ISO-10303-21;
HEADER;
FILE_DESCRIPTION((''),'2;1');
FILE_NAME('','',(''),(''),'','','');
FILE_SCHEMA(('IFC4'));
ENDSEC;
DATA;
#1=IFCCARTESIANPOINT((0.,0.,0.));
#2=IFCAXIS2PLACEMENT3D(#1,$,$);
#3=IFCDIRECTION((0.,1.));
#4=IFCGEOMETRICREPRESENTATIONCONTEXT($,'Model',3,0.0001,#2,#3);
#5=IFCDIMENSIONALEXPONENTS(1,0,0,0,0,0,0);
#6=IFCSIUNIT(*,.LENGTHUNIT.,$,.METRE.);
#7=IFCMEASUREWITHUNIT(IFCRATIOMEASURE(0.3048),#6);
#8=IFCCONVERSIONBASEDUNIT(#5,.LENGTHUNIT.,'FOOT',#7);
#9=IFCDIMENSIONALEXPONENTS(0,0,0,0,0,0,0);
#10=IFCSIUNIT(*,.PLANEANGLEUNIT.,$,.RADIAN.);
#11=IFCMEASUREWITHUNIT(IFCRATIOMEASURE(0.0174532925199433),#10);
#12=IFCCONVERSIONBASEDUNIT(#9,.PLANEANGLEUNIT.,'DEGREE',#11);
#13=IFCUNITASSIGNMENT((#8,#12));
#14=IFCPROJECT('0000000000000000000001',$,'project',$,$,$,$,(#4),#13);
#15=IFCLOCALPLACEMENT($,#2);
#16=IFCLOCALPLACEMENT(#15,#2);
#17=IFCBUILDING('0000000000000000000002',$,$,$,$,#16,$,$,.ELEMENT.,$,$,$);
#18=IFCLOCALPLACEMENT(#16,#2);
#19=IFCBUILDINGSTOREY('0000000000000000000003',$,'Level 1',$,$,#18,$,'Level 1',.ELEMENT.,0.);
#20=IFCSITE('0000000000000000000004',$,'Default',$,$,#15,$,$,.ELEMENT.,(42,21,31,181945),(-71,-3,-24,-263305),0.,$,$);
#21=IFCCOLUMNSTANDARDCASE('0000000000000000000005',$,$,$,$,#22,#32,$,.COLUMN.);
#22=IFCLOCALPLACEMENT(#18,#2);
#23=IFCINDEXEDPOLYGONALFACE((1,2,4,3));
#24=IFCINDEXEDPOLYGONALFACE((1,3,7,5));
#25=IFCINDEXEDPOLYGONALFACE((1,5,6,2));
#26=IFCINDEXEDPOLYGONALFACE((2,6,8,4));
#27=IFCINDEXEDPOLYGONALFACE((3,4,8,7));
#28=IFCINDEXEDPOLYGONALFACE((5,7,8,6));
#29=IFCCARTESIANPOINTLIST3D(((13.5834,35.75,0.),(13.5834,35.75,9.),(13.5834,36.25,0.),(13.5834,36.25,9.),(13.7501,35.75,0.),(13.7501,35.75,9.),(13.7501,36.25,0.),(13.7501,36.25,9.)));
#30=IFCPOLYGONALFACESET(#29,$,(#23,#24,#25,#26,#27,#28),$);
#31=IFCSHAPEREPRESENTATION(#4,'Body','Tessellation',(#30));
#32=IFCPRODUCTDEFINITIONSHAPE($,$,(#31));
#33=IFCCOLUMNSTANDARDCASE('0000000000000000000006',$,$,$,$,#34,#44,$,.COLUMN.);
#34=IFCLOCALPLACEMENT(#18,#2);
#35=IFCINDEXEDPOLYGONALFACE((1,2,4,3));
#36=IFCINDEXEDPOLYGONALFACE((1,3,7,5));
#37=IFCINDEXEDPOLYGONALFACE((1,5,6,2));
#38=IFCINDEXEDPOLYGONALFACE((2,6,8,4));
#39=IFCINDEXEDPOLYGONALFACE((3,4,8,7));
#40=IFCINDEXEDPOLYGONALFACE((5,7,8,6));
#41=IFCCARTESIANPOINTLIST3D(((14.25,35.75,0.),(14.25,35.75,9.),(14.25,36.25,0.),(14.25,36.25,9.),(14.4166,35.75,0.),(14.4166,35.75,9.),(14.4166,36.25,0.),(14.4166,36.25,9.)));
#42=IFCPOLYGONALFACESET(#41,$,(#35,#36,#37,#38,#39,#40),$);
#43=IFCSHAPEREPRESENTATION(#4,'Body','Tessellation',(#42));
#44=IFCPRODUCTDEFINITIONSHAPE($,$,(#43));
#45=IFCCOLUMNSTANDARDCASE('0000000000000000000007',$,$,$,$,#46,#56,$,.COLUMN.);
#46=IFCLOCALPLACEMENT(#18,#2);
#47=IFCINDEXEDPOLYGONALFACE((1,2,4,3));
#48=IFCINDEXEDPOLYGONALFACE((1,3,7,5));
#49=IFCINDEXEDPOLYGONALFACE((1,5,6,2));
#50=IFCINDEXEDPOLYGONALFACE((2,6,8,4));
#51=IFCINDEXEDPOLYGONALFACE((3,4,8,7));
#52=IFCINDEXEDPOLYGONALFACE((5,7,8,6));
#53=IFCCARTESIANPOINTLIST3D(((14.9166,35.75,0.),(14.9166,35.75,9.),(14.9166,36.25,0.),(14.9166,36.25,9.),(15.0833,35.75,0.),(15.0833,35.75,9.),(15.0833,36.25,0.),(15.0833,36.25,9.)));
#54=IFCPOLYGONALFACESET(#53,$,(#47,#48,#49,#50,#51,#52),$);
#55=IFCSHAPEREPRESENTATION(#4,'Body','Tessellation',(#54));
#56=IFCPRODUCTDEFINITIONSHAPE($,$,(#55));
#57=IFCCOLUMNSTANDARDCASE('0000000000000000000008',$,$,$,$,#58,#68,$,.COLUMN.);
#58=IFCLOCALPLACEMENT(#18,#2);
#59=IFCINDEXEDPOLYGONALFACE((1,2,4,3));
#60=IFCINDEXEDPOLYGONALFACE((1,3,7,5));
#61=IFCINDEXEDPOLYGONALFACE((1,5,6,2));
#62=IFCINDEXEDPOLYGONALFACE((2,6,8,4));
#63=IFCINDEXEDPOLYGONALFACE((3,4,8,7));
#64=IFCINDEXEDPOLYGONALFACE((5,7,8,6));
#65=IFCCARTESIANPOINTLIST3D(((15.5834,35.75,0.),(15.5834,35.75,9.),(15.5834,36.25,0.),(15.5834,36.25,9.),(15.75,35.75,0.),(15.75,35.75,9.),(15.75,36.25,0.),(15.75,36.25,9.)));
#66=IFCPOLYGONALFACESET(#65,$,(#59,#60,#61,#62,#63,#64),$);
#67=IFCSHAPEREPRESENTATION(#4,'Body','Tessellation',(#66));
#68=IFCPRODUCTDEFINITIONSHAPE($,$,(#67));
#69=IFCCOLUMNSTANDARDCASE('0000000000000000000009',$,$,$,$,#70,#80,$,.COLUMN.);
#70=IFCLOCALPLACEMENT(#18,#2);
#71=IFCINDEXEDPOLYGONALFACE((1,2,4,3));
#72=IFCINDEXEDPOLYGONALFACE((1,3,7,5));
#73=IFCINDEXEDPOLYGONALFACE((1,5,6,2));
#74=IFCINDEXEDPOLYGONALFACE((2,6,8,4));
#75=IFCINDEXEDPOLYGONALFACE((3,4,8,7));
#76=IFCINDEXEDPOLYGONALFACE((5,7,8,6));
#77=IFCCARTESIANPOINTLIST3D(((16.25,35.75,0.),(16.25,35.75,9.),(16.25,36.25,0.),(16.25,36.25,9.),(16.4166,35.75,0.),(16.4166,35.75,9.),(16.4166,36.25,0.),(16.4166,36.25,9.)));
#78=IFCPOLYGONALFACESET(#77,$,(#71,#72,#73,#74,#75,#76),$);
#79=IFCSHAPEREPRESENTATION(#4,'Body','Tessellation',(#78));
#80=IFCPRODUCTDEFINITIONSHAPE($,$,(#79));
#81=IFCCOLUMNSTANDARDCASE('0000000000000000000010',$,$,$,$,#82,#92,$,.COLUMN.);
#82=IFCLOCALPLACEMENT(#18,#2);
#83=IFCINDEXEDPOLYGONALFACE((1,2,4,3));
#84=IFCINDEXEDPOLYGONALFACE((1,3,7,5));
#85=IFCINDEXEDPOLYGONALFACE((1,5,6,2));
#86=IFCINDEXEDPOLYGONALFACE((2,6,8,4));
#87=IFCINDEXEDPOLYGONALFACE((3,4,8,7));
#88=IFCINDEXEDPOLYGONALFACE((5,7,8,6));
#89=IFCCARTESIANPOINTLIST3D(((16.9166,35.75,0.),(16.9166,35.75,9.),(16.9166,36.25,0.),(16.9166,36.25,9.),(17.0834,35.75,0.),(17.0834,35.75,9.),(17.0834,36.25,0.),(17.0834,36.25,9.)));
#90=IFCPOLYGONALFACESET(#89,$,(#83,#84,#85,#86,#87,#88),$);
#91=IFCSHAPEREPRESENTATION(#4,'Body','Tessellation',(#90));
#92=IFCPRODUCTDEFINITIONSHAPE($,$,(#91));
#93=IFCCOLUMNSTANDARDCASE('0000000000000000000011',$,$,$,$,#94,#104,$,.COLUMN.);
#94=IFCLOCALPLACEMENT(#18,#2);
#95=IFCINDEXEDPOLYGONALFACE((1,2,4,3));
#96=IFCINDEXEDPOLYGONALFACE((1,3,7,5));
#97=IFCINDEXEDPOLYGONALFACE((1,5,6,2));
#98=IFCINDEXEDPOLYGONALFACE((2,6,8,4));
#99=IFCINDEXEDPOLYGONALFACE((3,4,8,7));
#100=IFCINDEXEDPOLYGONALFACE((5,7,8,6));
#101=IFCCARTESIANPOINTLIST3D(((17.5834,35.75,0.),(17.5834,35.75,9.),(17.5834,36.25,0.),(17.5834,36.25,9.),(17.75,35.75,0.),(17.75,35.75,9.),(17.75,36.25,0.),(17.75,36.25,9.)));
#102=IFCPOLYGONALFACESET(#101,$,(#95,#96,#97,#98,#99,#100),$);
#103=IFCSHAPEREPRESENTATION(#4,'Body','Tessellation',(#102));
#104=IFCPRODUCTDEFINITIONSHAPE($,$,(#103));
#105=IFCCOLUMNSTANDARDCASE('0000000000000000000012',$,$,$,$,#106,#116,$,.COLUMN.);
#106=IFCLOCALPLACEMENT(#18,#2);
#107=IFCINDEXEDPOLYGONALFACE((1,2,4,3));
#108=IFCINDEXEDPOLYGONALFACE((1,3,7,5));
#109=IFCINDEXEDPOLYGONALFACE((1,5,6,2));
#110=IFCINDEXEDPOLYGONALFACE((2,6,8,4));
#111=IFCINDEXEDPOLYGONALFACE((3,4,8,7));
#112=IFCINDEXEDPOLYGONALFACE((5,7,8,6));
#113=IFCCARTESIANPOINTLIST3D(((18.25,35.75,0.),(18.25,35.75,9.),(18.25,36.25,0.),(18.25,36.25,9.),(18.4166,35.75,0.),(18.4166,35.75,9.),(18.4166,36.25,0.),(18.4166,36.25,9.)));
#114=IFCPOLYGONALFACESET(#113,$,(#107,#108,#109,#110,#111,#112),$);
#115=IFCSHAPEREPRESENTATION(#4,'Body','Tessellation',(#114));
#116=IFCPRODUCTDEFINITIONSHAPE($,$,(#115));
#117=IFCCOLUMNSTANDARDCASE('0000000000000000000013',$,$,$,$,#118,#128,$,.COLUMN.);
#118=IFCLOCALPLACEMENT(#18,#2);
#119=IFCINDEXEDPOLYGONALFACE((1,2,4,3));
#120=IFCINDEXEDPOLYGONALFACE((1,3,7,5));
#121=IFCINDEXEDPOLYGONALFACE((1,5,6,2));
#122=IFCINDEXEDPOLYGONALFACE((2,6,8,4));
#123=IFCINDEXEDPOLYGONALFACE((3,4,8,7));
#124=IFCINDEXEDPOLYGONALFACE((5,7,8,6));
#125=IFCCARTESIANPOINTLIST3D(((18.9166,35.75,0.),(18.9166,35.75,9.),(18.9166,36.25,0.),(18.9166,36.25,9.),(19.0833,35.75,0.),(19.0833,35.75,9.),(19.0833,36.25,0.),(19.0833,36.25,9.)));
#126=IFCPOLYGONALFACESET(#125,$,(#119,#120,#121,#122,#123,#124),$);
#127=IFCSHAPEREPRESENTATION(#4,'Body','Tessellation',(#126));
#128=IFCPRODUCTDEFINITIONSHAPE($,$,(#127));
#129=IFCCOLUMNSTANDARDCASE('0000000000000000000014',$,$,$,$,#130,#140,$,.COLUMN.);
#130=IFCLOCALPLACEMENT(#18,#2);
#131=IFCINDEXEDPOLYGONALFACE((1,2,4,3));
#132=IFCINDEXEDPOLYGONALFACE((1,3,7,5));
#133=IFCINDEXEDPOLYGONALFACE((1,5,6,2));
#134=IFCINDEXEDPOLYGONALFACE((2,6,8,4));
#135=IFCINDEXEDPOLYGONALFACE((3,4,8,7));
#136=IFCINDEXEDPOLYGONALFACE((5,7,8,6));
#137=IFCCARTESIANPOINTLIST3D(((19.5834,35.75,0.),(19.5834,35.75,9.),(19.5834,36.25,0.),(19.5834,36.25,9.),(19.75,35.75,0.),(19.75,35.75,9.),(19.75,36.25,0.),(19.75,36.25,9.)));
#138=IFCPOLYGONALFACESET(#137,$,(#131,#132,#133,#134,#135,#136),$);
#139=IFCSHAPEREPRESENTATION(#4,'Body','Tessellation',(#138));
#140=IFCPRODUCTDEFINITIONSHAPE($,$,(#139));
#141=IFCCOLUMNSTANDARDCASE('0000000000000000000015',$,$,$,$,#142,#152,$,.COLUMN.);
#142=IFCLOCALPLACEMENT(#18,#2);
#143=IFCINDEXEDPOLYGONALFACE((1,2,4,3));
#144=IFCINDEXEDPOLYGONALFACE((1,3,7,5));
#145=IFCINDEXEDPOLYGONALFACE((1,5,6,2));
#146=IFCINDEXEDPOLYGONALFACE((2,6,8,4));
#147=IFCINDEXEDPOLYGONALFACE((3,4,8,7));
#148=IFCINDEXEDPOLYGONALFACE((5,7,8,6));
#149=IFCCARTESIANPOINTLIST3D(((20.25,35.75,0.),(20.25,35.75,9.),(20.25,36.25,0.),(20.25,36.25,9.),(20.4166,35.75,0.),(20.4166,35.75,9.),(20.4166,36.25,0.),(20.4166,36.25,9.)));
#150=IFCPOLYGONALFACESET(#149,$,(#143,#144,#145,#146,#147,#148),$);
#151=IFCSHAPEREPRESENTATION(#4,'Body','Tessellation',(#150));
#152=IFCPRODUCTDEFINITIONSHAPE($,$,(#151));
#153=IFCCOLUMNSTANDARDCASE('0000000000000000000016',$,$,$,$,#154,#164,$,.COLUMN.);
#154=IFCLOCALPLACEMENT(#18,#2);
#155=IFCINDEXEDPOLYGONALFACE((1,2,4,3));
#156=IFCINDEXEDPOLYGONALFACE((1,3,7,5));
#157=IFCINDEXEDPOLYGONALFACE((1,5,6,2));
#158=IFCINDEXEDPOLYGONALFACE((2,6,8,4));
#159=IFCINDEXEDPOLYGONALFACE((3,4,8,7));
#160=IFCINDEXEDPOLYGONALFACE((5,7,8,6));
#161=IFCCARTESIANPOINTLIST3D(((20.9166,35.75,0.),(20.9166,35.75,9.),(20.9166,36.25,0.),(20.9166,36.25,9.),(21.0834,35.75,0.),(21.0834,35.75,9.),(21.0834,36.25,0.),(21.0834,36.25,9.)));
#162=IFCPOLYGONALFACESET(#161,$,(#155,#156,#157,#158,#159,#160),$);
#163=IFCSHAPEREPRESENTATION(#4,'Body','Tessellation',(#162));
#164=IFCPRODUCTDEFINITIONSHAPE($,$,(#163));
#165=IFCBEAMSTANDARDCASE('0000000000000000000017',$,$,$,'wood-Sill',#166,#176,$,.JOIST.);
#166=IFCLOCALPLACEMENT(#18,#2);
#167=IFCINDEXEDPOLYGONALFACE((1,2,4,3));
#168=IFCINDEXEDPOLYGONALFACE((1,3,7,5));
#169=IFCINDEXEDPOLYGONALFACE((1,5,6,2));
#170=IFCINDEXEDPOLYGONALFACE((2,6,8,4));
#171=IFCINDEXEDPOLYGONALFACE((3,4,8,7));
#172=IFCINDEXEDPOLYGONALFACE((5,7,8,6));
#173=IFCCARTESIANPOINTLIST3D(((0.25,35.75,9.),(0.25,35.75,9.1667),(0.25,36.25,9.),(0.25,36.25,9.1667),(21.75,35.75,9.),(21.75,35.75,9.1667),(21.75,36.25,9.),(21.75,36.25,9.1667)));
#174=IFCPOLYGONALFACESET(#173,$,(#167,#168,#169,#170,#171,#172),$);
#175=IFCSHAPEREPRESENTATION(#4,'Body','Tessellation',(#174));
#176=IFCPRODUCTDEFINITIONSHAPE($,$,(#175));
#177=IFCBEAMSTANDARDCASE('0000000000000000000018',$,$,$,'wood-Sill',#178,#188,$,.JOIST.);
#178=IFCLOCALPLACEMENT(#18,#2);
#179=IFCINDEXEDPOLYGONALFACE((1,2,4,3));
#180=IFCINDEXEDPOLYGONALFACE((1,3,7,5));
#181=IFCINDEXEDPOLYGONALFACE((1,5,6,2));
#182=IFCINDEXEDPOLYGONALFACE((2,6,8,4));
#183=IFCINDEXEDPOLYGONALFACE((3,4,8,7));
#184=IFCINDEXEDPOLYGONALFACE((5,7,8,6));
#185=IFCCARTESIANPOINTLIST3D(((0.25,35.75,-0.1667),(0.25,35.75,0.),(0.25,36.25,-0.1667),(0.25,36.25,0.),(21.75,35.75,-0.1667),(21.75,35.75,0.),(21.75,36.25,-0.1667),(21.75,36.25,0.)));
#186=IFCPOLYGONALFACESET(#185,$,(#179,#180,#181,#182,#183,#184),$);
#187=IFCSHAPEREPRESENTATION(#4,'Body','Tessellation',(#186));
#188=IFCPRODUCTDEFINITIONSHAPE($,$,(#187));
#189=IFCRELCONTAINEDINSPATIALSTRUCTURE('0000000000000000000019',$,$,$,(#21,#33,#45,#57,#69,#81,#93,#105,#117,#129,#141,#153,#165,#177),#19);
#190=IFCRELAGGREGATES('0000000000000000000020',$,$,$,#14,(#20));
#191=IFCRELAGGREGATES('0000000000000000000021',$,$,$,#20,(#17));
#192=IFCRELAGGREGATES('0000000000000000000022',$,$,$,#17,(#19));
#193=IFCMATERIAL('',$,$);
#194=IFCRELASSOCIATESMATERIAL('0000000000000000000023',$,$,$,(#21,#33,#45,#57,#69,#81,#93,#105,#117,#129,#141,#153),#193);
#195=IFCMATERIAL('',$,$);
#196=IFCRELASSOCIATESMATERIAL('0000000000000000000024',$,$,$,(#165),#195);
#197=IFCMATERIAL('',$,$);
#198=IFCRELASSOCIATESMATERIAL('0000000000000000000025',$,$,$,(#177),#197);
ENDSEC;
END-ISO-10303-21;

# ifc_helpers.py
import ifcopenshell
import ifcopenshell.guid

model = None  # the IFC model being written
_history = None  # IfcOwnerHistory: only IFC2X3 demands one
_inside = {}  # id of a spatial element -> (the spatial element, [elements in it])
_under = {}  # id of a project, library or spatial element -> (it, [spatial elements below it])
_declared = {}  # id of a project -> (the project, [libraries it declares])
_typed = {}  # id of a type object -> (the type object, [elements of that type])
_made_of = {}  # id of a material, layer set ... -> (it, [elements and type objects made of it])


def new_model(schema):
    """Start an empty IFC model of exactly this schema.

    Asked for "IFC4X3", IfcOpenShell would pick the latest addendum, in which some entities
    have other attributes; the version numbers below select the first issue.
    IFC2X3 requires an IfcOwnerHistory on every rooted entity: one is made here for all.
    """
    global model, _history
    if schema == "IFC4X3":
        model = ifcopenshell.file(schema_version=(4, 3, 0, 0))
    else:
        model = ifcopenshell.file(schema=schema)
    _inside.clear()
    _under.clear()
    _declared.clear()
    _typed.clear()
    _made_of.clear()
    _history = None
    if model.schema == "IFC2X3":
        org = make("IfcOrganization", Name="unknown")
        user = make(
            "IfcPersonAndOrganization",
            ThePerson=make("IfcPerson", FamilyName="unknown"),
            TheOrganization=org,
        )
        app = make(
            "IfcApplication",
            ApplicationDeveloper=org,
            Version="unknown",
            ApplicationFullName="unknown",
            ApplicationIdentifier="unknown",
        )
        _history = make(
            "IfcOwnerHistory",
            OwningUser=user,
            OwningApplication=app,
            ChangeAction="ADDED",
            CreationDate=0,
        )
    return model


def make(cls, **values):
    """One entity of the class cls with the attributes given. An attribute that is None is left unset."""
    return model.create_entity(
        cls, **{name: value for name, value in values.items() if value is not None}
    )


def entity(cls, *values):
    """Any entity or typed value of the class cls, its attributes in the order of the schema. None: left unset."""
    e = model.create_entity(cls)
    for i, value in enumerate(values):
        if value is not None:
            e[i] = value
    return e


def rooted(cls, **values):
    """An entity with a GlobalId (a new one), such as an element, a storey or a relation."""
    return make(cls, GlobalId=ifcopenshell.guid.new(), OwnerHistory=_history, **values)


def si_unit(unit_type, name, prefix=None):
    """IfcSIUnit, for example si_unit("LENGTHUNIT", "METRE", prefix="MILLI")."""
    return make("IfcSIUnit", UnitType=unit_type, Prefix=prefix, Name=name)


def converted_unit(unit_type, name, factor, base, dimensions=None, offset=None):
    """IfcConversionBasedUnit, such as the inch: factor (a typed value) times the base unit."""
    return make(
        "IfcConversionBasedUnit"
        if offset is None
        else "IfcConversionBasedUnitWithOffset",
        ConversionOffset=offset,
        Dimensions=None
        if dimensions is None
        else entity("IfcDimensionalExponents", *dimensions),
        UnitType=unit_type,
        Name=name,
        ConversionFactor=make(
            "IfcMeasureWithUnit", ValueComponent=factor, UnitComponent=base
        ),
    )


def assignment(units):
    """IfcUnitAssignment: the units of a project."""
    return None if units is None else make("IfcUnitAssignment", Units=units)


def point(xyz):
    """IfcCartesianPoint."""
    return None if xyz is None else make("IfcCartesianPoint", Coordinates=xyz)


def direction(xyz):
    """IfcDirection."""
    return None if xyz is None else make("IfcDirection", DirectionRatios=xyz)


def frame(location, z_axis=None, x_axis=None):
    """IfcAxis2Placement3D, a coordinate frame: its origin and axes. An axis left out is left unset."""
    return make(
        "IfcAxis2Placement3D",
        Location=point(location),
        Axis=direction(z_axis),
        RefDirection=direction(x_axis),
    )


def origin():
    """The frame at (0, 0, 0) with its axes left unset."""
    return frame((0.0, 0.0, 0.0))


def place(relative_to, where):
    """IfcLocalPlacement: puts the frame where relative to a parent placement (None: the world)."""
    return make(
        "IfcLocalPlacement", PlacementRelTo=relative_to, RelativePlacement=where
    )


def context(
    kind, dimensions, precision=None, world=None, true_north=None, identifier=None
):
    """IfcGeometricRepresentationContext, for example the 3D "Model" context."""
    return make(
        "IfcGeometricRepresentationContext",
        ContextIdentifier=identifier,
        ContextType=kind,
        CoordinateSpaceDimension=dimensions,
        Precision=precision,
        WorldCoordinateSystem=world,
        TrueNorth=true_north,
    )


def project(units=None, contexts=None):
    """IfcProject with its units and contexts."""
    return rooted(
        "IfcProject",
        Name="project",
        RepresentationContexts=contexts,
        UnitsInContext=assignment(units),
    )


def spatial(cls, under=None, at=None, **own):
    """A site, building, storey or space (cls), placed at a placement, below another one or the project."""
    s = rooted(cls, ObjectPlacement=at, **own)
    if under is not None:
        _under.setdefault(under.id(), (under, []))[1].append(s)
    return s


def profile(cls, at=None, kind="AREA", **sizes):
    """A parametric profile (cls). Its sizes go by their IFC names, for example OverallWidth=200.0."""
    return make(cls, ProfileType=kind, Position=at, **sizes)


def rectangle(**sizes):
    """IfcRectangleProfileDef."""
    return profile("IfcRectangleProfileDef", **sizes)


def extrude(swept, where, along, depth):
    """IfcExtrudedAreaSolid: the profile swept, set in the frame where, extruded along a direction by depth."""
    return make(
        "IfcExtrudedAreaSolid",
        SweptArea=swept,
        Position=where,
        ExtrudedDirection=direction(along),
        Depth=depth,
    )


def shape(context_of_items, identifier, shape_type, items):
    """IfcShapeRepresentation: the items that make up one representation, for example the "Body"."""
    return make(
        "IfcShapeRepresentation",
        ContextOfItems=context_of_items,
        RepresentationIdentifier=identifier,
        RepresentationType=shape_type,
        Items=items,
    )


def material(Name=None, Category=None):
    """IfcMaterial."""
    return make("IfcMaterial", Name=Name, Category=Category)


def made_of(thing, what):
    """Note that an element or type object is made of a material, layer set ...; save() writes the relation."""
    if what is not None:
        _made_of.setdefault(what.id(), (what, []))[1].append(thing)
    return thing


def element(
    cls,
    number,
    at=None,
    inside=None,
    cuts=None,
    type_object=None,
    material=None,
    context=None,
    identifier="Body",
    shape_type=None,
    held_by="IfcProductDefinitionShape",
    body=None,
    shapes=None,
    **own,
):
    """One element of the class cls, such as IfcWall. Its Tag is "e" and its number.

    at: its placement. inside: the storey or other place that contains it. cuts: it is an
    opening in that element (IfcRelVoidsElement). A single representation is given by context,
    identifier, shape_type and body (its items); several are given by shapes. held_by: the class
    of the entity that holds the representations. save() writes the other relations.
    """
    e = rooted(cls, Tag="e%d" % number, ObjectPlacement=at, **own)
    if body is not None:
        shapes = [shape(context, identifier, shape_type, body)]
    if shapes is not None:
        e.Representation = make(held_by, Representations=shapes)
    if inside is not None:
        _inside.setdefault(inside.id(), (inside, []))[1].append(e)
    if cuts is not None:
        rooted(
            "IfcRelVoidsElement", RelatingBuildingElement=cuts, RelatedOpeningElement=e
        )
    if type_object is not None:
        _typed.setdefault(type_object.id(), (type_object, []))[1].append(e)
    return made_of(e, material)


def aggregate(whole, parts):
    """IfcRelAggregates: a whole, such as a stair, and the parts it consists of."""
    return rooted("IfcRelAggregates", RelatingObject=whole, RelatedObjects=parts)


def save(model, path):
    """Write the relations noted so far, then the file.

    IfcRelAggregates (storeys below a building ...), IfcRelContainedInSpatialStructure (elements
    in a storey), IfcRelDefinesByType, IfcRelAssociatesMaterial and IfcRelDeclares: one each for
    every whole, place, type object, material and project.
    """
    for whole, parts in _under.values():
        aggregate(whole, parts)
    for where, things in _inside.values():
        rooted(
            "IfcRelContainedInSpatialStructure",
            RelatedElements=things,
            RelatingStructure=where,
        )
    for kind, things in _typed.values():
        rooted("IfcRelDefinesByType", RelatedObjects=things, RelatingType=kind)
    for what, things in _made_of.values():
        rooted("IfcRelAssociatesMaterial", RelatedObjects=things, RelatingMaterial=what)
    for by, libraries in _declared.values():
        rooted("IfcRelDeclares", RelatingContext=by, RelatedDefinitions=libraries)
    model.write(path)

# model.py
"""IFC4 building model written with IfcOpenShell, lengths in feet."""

from ifc_helpers import new_model, entity, si_unit, converted_unit, direction, frame, origin, place, context, project, spatial, rectangle, extrude, material, element, save


model = new_model("IFC4")

# Units and contexts
model_context = context("Model", 3, precision=0.0001, world=origin(), true_north=direction((0.0, 1.0)))
ifc_project = project(units=[converted_unit("LENGTHUNIT", "FOOT", entity("IfcRatioMeasure", 0.3048), si_unit("LENGTHUNIT", "METRE"), dimensions=[1, 0, 0, 0, 0, 0, 0]), converted_unit("PLANEANGLEUNIT", "DEGREE", entity("IfcRatioMeasure", 0.0174532925199433), si_unit("PLANEANGLEUNIT", "RADIAN"), dimensions=[0, 0, 0, 0, 0, 0, 0])], contexts=[model_context])

# Site, building, storey
site_placement = place(None, origin())
site = spatial("IfcSite", under=ifc_project, at=site_placement, Name="Default", CompositionType="ELEMENT", RefLatitude=(42, 21, 31, 181945), RefLongitude=(-71, -3, -24, -263305), RefElevation=0.0)
building_placement = place(site_placement, origin())
building = spatial("IfcBuilding", under=site, at=building_placement, CompositionType="ELEMENT")
storey_placement = place(building_placement, origin())
storey = spatial("IfcBuildingStorey", under=building, at=storey_placement, Name="Level 1", LongName="Level 1", CompositionType="ELEMENT", Elevation=0.0)

# Columns
ifc_material_1 = material(Name="")
placement = place(storey_placement, frame((0.25, 36.0, 0.0)))
for number, where, z_axis, x_axis in (
    (1, (13.4167, 0.0, 0.0), (0.0, 0.0, 1.0), (1.0, 0.0, 0.0)),
    (2, (14.0833, 0.0, 0.0), (0.0, 0.0, 1.0), (1.0, 0.0, 0.0)),
    (3, (14.75, 0.0, 0.0), (0.0, 0.0, 1.0), (1.0, 0.0, 0.0)),
    (4, (15.4167, 0.0, 0.0), (0.0, 0.0, 1.0), (1.0, 0.0, 0.0)),
    (5, (16.0833, 0.0, 0.0), (0.0, 0.0, 1.0), (1.0, 0.0, 0.0)),
    (6, (16.75, 0.0, 0.0), (0.0, 0.0, 1.0), (1.0, 0.0, 0.0)),
    (7, (17.4167, 0.0, 0.0), (0.0, 0.0, 1.0), (1.0, 0.0, 0.0)),
    (8, (18.0833, 0.0, 0.0), (0.0, 0.0, 1.0), (1.0, 0.0, 0.0)),
    (9, (18.75, 0.0, 0.0), (0.0, 0.0, 1.0), (1.0, 0.0, 0.0)),
    (10, (19.4167, 0.0, 0.0), (0.0, 0.0, 1.0), (1.0, 0.0, 0.0)),
    (11, (20.0833, 0.0, 0.0), (0.0, 0.0, 1.0), (1.0, 0.0, 0.0)),
    (12, (20.75, 0.0, 0.0), (0.0, 0.0, 1.0), (1.0, 0.0, 0.0)),
):
    element("IfcColumnStandardCase", number, at=place(placement, frame(where, z_axis=z_axis, x_axis=x_axis)), inside=storey, material=ifc_material_1, PredefinedType="COLUMN", context=model_context, shape_type="SweptSolid", body=[
        extrude(rectangle(XDim=0.1667, YDim=0.5), origin(), (0.0, 0.0, 1.0), 9.0),
    ])

# Beams
ifc_material_2 = material(Name="")
beam_1_placement = place(placement, frame((10.75, 0.0, 9.0), z_axis=(0.0, 0.0, 1.0), x_axis=(1.0, 0.0, 0.0)))
element("IfcBeamStandardCase", 13, at=beam_1_placement, inside=storey, material=ifc_material_2, ObjectType="wood-Sill", PredefinedType="JOIST", context=model_context, shape_type="SweptSolid", body=[
    extrude(rectangle(XDim=21.5, YDim=0.5), origin(), (0.0, 0.0, 1.0), 0.1667),
])
ifc_material_3 = material(Name="")
beam_2_placement = place(placement, frame((10.75, 0.0, -0.1667), z_axis=(0.0, 0.0, 1.0), x_axis=(1.0, 0.0, 0.0)))
element("IfcBeamStandardCase", 14, at=beam_2_placement, inside=storey, material=ifc_material_3, ObjectType="wood-Sill", PredefinedType="JOIST", context=model_context, shape_type="SweptSolid", body=[
    extrude(rectangle(XDim=21.5, YDim=0.5), origin(), (0.0, 0.0, 1.0), 0.1667),
])

save(model, "model.ifc")
